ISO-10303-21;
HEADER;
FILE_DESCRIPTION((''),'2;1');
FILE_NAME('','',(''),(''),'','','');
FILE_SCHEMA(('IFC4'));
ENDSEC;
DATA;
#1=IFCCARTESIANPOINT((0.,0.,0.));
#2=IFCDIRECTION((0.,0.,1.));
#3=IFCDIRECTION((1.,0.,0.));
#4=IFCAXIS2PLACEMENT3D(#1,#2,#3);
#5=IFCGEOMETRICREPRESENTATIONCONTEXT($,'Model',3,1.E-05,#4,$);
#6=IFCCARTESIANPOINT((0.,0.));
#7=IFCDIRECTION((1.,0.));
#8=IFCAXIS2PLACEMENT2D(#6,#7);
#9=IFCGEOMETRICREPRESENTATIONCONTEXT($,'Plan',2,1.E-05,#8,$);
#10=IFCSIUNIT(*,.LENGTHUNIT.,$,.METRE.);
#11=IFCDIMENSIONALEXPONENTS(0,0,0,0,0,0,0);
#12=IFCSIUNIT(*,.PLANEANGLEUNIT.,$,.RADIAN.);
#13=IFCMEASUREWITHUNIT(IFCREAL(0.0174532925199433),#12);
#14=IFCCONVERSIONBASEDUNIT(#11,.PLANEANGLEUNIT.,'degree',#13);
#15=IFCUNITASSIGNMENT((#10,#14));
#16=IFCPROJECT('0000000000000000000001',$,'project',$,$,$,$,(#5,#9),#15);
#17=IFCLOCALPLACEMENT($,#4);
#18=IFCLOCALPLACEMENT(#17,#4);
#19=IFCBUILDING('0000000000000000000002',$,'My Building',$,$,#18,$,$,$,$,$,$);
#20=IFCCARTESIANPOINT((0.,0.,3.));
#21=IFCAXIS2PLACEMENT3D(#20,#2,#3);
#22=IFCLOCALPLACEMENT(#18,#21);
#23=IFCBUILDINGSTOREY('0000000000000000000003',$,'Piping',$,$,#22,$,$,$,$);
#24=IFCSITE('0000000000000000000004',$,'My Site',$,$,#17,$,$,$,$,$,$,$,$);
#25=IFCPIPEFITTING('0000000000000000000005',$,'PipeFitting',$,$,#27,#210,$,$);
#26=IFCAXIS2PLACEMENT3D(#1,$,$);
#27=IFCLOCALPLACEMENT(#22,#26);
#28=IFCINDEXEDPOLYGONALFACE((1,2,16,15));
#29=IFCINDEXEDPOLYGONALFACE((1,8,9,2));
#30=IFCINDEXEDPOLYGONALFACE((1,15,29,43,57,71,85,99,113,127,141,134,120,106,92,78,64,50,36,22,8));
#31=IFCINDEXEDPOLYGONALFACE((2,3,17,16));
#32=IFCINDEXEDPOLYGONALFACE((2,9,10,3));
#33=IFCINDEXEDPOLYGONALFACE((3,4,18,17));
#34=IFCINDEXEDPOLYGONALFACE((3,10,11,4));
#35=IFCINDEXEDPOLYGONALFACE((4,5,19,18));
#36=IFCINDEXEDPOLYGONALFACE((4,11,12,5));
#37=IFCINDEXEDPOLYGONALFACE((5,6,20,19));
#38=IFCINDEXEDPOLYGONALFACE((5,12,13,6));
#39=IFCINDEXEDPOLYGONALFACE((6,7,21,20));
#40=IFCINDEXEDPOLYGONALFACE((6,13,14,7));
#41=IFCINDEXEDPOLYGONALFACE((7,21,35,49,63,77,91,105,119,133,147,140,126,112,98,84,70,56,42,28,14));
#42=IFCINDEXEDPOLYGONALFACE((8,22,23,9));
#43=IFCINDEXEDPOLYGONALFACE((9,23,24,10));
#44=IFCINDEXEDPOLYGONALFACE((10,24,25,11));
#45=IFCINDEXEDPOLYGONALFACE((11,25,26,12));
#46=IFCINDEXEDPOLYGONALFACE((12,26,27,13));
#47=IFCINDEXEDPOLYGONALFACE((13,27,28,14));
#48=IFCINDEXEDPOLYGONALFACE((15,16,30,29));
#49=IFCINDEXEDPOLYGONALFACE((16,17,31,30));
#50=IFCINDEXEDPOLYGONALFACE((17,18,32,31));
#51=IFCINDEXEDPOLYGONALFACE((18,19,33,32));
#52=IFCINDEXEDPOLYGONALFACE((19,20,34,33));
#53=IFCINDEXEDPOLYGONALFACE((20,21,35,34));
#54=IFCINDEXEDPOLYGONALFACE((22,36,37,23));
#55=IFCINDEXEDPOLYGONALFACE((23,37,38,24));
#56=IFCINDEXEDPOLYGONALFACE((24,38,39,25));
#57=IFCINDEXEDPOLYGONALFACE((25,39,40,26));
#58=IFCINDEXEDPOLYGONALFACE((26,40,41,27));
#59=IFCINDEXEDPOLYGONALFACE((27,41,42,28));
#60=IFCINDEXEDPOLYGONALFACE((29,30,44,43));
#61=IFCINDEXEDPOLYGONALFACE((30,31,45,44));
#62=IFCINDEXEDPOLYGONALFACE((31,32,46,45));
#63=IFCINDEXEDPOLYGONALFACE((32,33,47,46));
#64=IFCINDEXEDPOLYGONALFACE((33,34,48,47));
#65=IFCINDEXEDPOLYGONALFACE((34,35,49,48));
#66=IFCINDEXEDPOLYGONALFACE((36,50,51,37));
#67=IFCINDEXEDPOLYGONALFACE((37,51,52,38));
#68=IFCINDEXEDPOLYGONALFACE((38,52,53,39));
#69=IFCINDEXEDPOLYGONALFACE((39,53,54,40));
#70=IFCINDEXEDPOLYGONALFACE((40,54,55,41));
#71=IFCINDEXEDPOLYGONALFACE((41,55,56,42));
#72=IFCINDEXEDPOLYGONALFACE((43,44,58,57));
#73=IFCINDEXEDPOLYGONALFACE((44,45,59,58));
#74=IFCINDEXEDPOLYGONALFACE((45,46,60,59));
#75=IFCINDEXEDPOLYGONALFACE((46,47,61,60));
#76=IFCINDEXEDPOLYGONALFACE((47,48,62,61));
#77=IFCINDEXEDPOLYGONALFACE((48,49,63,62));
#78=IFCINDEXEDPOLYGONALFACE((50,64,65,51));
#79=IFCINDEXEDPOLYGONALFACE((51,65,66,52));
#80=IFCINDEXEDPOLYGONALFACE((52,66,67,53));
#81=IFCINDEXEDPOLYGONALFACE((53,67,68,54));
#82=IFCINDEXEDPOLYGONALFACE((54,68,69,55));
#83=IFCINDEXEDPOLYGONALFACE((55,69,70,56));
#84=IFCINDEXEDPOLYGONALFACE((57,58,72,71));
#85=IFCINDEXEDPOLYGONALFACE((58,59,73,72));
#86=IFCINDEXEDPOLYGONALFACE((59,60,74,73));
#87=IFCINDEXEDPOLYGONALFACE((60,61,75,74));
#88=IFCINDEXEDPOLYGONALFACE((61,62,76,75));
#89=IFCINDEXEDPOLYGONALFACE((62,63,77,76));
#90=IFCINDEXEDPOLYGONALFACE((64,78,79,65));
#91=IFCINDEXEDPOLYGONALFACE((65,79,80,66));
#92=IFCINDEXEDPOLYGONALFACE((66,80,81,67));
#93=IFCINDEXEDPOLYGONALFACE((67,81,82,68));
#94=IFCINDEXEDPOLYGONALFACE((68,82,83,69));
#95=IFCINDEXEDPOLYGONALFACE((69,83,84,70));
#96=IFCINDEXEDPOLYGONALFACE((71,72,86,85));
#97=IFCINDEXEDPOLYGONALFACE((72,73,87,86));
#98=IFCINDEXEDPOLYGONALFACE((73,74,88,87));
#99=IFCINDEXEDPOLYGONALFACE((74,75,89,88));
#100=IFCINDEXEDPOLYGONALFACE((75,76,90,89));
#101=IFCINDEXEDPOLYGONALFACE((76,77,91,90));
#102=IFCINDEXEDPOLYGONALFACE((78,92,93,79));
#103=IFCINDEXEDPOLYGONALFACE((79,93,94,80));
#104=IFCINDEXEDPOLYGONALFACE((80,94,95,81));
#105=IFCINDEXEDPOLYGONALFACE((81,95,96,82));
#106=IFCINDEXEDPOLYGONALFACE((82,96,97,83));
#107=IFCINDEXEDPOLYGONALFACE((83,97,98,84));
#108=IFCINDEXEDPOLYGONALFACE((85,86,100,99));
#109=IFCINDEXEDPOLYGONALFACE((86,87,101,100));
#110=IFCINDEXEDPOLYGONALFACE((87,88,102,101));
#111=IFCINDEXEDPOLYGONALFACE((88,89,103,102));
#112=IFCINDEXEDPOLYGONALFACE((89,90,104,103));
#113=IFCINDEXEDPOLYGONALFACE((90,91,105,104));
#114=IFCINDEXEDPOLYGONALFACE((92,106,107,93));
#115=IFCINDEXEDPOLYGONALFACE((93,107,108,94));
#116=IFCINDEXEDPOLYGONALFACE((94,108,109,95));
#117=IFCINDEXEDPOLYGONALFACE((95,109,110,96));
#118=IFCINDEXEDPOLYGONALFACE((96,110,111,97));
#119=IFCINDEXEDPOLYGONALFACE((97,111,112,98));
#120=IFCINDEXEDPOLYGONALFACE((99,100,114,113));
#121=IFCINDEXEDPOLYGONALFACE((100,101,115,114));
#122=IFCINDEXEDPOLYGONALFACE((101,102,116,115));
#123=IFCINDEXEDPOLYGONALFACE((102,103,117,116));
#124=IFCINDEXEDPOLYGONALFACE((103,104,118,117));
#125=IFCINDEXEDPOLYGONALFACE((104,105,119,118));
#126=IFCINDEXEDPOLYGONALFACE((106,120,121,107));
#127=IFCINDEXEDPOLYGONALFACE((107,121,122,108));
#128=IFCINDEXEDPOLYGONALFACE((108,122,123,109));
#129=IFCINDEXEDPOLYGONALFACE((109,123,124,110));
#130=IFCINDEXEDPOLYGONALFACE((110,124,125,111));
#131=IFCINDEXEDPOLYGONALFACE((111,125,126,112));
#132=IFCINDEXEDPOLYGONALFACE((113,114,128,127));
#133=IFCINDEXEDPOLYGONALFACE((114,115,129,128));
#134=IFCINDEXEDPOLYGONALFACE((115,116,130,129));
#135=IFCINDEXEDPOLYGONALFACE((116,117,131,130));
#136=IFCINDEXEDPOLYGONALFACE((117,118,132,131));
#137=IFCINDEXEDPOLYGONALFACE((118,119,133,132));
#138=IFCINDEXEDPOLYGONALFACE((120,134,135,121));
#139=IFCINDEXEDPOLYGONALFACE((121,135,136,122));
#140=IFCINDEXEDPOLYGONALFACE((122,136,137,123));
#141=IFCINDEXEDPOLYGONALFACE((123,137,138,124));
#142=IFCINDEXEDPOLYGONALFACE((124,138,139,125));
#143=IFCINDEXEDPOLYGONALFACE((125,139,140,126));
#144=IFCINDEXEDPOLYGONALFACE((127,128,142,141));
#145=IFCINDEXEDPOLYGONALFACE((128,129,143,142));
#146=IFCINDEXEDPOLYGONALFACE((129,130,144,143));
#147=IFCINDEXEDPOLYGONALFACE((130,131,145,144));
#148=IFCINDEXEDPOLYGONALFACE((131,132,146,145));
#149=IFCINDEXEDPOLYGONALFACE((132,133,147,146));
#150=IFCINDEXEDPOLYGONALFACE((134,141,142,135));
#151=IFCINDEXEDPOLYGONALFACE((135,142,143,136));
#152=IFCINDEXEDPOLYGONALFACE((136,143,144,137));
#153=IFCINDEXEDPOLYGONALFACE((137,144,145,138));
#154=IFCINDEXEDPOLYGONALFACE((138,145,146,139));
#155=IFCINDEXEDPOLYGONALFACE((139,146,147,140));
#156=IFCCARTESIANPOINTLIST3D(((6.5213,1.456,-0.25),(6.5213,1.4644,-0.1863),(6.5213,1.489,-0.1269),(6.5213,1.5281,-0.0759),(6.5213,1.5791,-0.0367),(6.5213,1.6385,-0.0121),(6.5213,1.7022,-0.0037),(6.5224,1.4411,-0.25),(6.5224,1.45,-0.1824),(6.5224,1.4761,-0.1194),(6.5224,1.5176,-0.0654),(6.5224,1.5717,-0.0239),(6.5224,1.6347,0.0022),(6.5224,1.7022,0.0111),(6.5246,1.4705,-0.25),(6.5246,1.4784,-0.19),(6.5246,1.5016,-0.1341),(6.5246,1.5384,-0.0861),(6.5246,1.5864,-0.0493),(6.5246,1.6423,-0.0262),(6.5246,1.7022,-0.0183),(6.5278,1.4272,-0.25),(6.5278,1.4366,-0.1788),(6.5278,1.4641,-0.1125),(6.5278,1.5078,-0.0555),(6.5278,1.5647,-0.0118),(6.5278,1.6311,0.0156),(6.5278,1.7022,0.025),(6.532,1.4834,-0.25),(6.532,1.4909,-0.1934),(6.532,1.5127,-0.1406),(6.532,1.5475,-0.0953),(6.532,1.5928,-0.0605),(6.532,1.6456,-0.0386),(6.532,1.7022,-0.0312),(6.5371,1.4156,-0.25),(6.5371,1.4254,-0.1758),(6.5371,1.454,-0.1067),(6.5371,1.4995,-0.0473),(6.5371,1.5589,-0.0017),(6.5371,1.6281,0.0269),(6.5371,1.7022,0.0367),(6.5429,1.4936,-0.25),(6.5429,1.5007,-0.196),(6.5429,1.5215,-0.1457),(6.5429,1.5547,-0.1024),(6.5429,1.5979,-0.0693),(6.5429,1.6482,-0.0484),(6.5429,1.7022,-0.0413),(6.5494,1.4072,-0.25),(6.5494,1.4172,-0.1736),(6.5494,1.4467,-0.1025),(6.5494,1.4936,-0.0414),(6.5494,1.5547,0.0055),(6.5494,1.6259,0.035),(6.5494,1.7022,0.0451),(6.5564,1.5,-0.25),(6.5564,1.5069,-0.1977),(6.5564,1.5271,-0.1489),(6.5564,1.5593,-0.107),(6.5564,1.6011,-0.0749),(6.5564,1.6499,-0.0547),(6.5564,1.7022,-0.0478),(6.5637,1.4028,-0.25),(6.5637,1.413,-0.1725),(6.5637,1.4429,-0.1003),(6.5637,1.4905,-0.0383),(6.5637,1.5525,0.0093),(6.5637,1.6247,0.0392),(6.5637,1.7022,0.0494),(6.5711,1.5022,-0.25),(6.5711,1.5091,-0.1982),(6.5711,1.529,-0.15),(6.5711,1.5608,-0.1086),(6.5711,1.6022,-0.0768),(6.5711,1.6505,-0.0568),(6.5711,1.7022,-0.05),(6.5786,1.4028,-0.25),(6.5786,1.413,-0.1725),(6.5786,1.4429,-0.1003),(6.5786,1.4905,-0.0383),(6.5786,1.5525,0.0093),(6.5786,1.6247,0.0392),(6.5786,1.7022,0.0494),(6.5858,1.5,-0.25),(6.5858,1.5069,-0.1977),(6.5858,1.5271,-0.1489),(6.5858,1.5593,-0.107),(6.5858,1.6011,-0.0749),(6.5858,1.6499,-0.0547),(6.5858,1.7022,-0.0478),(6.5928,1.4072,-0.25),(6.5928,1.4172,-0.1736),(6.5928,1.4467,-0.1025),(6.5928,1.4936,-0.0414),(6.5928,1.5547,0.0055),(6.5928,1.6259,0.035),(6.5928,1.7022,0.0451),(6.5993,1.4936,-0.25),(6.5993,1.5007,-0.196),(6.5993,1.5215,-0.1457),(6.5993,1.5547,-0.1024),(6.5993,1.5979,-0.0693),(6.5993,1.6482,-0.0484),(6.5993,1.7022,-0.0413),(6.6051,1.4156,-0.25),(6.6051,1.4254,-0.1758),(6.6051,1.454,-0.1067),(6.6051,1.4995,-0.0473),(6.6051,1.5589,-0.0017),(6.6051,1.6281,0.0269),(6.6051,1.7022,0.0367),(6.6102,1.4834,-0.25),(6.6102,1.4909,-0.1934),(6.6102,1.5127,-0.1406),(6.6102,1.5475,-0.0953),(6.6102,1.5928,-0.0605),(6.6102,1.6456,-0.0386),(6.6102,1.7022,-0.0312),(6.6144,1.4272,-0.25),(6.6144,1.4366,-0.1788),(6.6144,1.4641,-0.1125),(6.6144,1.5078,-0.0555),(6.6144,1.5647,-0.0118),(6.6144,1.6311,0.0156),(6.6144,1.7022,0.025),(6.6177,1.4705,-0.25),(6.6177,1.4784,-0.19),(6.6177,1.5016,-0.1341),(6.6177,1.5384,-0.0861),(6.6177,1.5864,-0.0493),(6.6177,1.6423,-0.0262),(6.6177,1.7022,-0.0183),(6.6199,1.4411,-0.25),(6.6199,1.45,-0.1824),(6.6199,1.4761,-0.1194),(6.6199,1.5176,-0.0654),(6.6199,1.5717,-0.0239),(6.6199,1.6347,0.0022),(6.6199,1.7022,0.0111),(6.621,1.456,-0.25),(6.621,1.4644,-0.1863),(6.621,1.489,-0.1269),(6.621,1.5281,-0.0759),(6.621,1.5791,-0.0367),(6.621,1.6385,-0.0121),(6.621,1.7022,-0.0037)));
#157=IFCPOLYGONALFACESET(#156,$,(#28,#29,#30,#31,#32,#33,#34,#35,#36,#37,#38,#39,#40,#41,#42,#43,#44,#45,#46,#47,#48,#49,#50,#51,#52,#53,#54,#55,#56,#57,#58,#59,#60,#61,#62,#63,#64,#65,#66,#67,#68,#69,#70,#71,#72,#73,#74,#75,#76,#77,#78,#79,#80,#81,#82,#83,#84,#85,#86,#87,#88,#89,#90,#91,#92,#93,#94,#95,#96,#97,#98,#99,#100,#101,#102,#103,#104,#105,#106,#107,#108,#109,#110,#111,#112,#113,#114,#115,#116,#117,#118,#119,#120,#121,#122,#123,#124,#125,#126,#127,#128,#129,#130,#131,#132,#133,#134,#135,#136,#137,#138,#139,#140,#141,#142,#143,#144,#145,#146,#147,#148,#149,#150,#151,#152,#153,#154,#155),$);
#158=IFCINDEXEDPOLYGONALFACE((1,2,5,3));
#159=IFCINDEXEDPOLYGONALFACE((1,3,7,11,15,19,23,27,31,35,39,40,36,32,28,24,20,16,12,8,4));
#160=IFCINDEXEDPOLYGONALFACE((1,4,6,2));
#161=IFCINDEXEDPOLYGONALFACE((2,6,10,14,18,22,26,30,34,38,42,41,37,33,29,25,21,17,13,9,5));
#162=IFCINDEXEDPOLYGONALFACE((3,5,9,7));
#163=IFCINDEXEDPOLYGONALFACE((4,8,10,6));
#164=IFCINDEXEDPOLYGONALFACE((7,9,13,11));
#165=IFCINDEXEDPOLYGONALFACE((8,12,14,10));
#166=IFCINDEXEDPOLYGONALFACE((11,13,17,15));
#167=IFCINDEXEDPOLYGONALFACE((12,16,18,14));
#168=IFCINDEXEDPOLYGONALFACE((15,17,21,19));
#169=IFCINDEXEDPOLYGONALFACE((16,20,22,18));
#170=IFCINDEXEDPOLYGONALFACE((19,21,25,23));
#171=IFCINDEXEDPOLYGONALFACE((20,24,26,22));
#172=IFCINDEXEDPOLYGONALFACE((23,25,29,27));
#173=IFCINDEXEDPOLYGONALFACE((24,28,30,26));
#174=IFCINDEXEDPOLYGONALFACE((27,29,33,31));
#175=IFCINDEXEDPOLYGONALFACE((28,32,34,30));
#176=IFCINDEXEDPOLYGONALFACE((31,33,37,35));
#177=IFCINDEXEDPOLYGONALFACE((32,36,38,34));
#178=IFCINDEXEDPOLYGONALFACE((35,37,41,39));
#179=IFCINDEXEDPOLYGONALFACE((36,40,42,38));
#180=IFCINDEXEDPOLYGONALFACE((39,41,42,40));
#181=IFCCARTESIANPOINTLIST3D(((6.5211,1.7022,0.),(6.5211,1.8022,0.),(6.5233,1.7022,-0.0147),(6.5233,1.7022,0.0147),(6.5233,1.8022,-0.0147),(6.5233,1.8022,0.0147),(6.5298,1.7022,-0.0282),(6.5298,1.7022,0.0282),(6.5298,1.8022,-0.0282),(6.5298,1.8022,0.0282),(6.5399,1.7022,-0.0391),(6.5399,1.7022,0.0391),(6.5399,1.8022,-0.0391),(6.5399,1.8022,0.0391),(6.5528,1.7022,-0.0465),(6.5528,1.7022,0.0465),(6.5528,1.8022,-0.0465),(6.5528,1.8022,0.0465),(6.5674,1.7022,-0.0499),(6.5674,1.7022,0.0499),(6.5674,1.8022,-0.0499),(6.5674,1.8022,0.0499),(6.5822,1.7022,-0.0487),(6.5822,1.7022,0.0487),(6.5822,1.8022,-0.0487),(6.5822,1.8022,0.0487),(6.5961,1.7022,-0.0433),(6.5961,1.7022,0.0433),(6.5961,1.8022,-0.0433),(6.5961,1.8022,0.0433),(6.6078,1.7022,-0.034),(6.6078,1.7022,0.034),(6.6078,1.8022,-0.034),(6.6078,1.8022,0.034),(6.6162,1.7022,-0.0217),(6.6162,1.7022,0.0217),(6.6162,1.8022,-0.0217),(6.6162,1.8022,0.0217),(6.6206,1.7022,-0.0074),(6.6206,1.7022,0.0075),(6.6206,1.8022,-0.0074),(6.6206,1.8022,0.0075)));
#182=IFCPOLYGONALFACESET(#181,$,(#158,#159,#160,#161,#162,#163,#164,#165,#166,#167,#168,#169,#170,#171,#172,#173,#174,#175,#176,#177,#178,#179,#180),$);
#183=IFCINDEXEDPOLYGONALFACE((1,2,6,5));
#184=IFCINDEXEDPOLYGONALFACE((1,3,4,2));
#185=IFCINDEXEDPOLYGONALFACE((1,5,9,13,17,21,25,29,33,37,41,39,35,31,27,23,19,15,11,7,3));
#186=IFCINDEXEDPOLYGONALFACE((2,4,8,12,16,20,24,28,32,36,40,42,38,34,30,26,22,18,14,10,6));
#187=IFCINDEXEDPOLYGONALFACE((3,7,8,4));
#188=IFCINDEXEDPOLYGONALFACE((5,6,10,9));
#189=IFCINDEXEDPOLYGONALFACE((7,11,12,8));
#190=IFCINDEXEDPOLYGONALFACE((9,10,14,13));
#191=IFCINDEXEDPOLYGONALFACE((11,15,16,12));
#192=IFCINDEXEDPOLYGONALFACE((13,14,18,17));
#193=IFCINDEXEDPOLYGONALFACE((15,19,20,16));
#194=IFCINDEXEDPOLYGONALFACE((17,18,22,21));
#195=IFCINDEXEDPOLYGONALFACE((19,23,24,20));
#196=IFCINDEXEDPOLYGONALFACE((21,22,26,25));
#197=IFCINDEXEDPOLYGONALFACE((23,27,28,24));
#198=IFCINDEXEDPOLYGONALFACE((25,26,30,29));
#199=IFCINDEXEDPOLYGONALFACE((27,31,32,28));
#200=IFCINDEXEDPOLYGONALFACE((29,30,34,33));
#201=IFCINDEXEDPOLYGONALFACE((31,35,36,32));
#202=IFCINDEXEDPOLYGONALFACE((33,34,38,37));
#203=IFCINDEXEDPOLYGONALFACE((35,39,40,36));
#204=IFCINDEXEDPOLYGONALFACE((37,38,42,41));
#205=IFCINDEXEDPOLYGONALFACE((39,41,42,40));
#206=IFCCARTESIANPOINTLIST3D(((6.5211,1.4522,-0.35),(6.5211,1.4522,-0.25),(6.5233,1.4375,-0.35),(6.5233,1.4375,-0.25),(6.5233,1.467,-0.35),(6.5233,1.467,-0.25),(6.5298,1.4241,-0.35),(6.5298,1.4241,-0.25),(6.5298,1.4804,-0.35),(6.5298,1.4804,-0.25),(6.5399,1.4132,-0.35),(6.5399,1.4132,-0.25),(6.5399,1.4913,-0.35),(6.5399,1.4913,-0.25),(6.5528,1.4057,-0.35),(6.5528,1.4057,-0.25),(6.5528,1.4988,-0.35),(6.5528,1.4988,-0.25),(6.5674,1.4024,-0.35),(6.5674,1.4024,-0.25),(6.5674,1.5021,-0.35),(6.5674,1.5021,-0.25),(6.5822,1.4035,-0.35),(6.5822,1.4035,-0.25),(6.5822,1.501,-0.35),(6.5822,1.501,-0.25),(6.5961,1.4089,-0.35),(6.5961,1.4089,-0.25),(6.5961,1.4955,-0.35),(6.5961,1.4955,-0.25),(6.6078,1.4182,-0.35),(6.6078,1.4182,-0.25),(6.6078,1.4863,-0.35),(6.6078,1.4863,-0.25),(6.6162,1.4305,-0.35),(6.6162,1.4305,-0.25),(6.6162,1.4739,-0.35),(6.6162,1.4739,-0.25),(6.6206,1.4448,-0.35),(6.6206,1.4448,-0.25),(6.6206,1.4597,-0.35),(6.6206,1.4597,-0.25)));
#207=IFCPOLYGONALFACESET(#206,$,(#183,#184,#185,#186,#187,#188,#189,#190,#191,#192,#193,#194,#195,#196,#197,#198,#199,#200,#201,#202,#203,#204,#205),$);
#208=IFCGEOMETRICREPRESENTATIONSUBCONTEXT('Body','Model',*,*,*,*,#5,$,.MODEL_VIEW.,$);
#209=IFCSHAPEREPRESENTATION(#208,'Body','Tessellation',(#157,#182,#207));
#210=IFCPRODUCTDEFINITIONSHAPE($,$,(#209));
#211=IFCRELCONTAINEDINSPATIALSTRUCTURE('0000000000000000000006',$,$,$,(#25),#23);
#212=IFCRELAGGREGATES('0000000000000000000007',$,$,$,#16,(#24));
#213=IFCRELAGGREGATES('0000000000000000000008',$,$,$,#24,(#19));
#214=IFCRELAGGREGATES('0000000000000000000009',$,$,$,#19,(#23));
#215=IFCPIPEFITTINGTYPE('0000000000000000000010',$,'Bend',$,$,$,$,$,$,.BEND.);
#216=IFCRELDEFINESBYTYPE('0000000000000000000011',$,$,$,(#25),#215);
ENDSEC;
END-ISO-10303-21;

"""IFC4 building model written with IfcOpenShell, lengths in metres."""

from ifc_helpers import new_model, entity, si_unit, converted_unit, frame, origin_with_axes, origin_2d_with_axis, place, context, subcontext, project, spatial, circle, extrude, source, transform, mapped, type_object, type_shapes, element, save


model = new_model("IFC4")

# Units and contexts
model_context = context("Model", 3, precision=1e-05, world=origin_with_axes())
plan_context = context("Plan", 2, precision=1e-05, world=origin_2d_with_axis())
body_context = subcontext(model_context, "Body", "Model", "MODEL_VIEW")
ifc_project = project(units=[si_unit("LENGTHUNIT", "METRE"), converted_unit("PLANEANGLEUNIT", "degree", entity("IfcReal", 0.0174532925199433), si_unit("PLANEANGLEUNIT", "RADIAN"), dimensions=[0, 0, 0, 0, 0, 0, 0])], contexts=[model_context, plan_context])

# Site, building, storey
site_placement = place(None, origin_with_axes())
site = spatial("IfcSite", under=ifc_project, at=site_placement, Name="My Site")
building_placement = place(site_placement, origin_with_axes())
building = spatial("IfcBuilding", under=site, at=building_placement, Name="My Building")
storey_placement = place(building_placement, frame((0.0, 0.0, 3.0), z_axis=(0.0, 0.0, 1.0), x_axis=(1.0, 0.0, 0.0)))
storey = spatial("IfcBuildingStorey", under=building, at=storey_placement, Name="Piping")

# Pipe fitting
pipe_fitting_type = type_object("IfcPipeFittingType", Name="Bend", PredefinedType="BEND")
shared_shape = source(origin_with_axes(), body_context, "Body", "SolidModel", [
    entity("IfcSweptDiskSolid", entity("IfcIndexedPolyCurve", entity("IfcCartesianPointList3D", [[0.0, 0.0, -0.1], [0.0, -0.0732, -0.2768], [0.0, -0.25, -0.35]]), [entity("IfcArcIndex", [1, 2, 3])]), 0.05),
    extrude(circle(Radius=0.05), origin_with_axes(), (0.0, 0.0, -1.0), 0.1),
    extrude(circle(Radius=0.05), frame((0.0, -0.25, -0.35), z_axis=(0.0, -1.0, 0.0), x_axis=(1.0, 0.0, 0.0)), (0.0, 0.0, 1.0), 0.1),
])
type_shapes(pipe_fitting_type, [shared_shape])
for number, where, z_axis, x_axis, name in (
    (1, (6.5711, 1.8022, 0.0), (0.0, 1.0, 0.0), (-1.0, 0.0, 0.0), "PipeFitting"),
):
    element("IfcPipeFitting", number, at=place(storey_placement, frame(where, z_axis=z_axis, x_axis=x_axis)), inside=storey, type_object=pipe_fitting_type, Name=name, context=body_context, shape_type="MappedRepresentation", body=[
        mapped(shared_shape, transform((0.0, 0.0, 0.0), x_axis=(1.0, 0.0, 0.0), y_axis=(0.0, 1.0, 0.0), z_axis=(0.0, 0.0, 1.0), scale=1.0)),
    ])

save(model, "model.ifc")
